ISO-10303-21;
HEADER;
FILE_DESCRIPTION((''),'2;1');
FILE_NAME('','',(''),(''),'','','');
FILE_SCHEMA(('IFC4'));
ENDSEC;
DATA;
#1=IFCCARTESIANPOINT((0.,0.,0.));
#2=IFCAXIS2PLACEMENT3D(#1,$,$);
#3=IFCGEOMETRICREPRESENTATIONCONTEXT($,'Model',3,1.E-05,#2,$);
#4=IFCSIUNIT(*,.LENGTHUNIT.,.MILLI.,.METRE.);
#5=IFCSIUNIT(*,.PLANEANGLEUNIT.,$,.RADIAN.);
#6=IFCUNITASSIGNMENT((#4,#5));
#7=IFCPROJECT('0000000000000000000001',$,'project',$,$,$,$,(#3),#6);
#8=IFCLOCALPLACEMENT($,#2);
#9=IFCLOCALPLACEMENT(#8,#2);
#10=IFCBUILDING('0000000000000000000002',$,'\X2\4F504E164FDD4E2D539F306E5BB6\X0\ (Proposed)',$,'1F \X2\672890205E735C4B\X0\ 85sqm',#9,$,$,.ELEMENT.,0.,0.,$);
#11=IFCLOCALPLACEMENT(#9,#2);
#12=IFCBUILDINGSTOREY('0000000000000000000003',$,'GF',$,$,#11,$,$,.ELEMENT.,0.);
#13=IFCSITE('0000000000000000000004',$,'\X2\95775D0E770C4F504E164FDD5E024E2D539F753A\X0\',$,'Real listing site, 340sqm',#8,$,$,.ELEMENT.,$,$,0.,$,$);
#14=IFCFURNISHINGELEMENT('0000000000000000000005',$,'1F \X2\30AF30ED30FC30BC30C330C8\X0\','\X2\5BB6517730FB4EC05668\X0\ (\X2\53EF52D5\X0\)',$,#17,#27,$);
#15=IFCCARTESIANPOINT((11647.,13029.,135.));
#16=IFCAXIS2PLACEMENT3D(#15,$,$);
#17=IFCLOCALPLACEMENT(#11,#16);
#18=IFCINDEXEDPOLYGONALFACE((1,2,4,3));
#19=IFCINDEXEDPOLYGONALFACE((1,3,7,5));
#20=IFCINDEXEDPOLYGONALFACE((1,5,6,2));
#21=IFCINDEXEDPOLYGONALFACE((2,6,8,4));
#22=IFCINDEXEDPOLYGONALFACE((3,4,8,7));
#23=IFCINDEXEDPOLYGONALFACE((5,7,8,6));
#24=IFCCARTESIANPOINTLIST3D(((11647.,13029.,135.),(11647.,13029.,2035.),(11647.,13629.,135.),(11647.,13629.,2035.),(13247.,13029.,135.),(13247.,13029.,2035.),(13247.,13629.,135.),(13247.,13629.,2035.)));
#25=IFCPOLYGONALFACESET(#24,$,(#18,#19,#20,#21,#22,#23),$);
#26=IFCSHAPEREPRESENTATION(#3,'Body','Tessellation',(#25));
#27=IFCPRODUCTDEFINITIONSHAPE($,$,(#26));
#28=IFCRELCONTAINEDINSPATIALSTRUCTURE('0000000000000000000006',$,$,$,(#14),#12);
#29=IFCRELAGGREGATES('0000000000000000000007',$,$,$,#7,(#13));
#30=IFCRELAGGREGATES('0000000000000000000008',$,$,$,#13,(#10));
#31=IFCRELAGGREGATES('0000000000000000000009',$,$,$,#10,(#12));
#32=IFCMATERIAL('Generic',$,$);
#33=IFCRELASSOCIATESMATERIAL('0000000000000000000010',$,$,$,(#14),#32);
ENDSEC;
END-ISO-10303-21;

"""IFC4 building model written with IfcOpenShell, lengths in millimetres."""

from ifc_helpers import new_model, si_unit, frame, frame_2d, origin, place, context, project, spatial, rectangle, extrude, material, element, save


model = new_model("IFC4")

# Units and contexts
model_context = context("Model", 3, precision=1e-05, world=origin())
ifc_project = project(units=[si_unit("LENGTHUNIT", "METRE", prefix="MILLI"), si_unit("PLANEANGLEUNIT", "RADIAN")], contexts=[model_context])

# Site, building, storey
site_placement = place(None, origin())
site = spatial("IfcSite", under=ifc_project, at=site_placement, Name="長崎県佐世保市中原町", ObjectType="Real listing site, 340sqm", CompositionType="ELEMENT", RefElevation=0.0)
building_placement = place(site_placement, origin())
building = spatial("IfcBuilding", under=site, at=building_placement, Name="佐世保中原の家 (Proposed)", ObjectType="1F 木造平屋 85sqm", CompositionType="ELEMENT", ElevationOfRefHeight=0.0, ElevationOfTerrain=0.0)
storey_placement = place(building_placement, origin())
storey = spatial("IfcBuildingStorey", under=building, at=storey_placement, Name="GF", CompositionType="ELEMENT", Elevation=0.0)

# Shared definitions
ifc_material_1 = material(Name="Generic")

# Furnishing element
furnishing_placement = place(storey_placement, frame((11647.0, 13029.0, 135.0)))
element("IfcFurnishingElement", 1, at=furnishing_placement, inside=storey, material=ifc_material_1, Name="1F クローゼット", Description="家具・什器 (可動)", context=model_context, shape_type="SweptSolid", body=[
    extrude(rectangle(XDim=1600.0, YDim=600.0, at=frame_2d((800.0, 300.0))), frame((11647.0, 13029.0, 135.0)), (0.0, 0.0, 1.0), 1900.0),
])

save(model, "model.ifc")
